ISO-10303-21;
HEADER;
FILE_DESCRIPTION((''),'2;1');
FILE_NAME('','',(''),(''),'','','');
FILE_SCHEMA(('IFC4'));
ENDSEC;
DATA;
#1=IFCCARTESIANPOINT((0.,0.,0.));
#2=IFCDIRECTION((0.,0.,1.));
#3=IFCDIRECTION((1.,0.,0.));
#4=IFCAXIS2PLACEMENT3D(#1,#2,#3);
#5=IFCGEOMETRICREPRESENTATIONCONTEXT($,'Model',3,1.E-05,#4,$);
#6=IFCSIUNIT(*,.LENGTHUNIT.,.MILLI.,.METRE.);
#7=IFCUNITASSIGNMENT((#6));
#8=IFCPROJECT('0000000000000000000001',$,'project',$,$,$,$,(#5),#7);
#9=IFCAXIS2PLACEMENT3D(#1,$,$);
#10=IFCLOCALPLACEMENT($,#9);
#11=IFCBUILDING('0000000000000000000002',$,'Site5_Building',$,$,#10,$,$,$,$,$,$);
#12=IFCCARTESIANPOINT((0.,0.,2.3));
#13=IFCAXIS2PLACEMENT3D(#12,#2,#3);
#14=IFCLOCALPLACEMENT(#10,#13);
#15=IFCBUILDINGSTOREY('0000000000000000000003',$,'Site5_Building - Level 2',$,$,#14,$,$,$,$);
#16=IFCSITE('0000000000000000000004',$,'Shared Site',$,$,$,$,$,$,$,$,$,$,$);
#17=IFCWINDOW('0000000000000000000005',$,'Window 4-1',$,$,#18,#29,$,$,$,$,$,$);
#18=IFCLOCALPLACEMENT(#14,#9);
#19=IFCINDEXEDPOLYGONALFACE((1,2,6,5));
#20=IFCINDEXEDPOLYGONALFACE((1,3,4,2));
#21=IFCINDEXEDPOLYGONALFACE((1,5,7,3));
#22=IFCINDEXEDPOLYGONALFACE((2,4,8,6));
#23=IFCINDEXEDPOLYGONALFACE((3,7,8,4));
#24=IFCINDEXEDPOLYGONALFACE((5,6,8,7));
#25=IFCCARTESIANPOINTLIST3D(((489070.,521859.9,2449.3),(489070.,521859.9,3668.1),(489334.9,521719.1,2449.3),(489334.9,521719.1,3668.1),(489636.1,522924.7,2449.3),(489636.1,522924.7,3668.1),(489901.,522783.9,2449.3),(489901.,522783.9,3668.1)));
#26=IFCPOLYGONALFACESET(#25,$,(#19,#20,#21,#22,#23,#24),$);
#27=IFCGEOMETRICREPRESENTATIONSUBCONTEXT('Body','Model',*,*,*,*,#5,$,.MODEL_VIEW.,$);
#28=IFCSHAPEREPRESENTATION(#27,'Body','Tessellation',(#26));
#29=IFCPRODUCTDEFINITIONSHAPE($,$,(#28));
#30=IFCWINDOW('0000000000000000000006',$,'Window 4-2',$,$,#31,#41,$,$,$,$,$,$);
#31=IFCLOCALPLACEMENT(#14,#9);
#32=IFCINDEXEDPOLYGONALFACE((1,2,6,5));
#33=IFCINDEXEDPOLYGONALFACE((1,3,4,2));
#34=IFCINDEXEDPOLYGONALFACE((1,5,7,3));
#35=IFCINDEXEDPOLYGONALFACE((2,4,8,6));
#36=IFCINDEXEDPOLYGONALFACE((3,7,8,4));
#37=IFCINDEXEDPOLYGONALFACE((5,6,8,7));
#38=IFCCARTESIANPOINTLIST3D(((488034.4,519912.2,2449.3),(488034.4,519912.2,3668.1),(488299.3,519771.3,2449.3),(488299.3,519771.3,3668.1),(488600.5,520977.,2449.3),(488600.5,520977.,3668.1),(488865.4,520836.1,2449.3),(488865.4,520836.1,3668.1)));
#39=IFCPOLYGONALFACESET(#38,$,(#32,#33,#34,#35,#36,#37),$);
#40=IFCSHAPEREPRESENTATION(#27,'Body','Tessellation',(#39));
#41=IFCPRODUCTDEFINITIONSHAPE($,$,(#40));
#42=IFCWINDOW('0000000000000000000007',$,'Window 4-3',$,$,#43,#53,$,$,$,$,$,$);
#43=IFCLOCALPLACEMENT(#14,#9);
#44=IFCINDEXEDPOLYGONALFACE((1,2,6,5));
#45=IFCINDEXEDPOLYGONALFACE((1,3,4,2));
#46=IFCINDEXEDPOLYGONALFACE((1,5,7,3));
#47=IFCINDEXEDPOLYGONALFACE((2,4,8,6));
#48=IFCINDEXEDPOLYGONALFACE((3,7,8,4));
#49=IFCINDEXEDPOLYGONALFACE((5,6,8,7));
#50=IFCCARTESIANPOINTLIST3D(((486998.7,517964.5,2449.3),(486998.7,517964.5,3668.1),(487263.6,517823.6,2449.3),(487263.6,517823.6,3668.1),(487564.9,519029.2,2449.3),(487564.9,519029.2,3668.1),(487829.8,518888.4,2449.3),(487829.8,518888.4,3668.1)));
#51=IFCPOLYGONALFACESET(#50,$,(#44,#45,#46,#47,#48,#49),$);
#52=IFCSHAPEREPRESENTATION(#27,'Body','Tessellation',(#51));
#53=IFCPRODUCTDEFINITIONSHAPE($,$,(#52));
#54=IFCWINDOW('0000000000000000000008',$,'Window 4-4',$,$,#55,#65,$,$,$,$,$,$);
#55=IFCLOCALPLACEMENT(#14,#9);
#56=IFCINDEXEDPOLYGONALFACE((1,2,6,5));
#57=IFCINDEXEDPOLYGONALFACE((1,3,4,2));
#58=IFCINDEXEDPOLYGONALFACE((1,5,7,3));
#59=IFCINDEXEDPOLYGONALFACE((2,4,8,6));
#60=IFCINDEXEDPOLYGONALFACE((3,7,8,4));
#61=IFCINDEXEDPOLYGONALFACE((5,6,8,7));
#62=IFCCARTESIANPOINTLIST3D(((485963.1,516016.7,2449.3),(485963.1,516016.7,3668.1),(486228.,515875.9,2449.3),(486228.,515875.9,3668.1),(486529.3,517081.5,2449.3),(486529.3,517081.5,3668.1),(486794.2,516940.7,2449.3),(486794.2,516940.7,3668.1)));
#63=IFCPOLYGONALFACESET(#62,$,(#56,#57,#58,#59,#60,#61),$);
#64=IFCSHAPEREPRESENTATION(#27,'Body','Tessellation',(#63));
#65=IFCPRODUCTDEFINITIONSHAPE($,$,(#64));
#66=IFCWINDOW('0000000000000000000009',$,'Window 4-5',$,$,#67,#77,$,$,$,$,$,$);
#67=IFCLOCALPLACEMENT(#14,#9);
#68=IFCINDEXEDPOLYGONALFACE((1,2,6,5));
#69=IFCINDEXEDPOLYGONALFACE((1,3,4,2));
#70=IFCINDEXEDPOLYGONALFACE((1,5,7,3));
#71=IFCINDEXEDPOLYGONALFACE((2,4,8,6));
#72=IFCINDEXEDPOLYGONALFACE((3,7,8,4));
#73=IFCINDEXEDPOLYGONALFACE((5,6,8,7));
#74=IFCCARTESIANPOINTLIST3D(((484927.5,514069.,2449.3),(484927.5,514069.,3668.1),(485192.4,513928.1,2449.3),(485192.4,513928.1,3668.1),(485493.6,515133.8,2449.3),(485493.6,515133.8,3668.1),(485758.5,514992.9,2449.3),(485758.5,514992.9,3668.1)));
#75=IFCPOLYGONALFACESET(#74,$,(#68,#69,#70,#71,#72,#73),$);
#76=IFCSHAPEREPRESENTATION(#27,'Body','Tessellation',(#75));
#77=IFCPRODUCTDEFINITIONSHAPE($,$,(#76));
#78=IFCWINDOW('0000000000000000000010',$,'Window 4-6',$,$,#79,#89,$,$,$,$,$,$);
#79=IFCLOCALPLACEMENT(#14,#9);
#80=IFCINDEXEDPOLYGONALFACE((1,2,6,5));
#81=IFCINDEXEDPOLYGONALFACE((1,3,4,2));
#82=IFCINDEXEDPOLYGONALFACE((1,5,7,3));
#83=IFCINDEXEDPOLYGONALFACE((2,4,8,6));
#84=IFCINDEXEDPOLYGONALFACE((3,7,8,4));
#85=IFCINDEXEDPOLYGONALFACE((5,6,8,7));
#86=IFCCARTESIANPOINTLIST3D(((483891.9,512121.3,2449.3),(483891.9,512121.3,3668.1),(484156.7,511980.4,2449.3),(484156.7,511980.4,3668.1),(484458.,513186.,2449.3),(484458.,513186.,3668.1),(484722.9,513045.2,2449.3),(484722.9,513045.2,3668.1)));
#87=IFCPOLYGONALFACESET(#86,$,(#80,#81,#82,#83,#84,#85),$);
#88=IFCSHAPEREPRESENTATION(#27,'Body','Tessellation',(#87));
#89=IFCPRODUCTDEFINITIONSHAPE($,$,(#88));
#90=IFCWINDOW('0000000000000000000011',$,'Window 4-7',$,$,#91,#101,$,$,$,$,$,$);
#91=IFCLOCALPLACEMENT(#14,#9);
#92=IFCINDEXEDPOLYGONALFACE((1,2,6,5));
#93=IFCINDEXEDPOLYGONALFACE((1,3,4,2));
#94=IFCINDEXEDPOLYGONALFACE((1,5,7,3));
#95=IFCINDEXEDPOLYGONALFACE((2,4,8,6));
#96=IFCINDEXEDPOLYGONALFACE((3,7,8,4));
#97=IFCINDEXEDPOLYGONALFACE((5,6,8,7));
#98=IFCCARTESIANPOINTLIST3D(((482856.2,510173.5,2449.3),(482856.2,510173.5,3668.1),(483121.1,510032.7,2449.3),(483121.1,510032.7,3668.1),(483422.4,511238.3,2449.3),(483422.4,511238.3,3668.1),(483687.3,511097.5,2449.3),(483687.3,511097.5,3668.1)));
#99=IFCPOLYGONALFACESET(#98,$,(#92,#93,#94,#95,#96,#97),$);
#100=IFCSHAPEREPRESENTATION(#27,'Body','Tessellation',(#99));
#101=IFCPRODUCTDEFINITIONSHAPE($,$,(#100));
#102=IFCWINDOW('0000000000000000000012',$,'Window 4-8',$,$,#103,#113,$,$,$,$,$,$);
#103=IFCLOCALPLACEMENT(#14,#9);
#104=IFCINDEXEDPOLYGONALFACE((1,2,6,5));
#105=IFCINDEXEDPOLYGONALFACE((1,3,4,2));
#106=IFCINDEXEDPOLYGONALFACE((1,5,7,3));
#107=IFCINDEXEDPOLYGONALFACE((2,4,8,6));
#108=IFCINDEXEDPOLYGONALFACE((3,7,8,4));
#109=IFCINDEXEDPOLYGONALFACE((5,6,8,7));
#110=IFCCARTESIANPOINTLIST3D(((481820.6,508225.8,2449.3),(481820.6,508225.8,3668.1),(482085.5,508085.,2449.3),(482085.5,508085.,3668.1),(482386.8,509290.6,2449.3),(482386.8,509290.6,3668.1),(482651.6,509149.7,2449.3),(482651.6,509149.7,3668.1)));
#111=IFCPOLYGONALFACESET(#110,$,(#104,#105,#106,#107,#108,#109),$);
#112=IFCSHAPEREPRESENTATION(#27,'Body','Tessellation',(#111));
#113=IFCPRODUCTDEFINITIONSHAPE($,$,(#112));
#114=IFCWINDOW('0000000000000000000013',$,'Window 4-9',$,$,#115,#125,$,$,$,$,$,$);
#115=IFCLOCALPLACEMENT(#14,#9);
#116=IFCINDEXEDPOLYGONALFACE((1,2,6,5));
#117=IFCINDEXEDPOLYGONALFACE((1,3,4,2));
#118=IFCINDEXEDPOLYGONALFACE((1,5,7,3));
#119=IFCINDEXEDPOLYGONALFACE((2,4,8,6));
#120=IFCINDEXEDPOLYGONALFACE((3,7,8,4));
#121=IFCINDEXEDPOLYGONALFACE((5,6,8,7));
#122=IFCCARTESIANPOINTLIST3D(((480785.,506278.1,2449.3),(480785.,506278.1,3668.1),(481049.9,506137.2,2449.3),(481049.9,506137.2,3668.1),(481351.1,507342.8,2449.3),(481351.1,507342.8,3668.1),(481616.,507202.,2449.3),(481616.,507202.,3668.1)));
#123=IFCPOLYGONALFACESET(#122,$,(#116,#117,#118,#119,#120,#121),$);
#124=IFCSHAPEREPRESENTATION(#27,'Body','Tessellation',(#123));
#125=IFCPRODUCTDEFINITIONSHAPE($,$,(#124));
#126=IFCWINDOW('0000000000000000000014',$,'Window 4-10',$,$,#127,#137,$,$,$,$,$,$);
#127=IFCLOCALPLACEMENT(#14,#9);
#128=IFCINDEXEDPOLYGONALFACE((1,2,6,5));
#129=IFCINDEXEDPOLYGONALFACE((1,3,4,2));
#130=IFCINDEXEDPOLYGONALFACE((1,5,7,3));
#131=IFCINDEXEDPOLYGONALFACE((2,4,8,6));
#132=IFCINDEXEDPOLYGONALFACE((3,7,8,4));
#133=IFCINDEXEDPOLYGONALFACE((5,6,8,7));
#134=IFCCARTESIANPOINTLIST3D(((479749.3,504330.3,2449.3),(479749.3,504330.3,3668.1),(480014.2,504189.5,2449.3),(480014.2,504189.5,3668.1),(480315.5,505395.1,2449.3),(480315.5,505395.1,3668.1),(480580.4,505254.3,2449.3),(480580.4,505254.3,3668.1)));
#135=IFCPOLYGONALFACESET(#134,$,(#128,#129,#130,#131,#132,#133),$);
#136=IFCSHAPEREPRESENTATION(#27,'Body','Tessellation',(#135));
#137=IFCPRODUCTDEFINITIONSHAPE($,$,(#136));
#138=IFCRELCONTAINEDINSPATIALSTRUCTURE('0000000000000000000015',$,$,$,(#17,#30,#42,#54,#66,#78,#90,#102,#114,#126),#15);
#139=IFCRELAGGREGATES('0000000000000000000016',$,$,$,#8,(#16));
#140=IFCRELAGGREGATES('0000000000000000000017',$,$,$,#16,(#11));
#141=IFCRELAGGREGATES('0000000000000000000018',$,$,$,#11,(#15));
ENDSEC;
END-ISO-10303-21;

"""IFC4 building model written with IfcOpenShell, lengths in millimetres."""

from ifc_helpers import new_model, si_unit, frame, origin, origin_with_axes, place, context, subcontext, project, spatial, indexed_curve, outline, extrude, element, save


model = new_model("IFC4")

# Units and contexts
model_context = context("Model", 3, precision=1e-05, world=origin_with_axes())
body_context = subcontext(model_context, "Body", "Model", "MODEL_VIEW")
ifc_project = project(units=[si_unit("LENGTHUNIT", "METRE", prefix="MILLI")], contexts=[model_context])

# Site, building, storey
site = spatial("IfcSite", under=ifc_project, Name="Shared Site")
building_placement = place(None, origin())
building = spatial("IfcBuilding", under=site, at=building_placement, Name="Site5_Building")
storey_placement = place(building_placement, frame((0.0, 0.0, 2.3), z_axis=(0.0, 0.0, 1.0), x_axis=(1.0, 0.0, 0.0)))
storey = spatial("IfcBuildingStorey", under=building, at=storey_placement, Name="Site5_Building - Level 2")

# Windows
for number, where, z_axis, x_axis, name in (
    (1, (489636.1, 522924.7, 2449.3), (0.0, 0.0, 1.0), (-0.469472, -0.882948, 0.0), "Window 4-1"),
    (2, (488600.5, 520977.0, 2449.3), (0.0, 0.0, 1.0), (-0.469472, -0.882948, 0.0), "Window 4-2"),
    (3, (487564.9, 519029.2, 2449.3), (0.0, 0.0, 1.0), (-0.469472, -0.882948, 0.0), "Window 4-3"),
    (4, (486529.3, 517081.5, 2449.3), (0.0, 0.0, 1.0), (-0.469472, -0.882948, 0.0), "Window 4-4"),
    (5, (485493.6, 515133.8, 2449.3), (0.0, 0.0, 1.0), (-0.469472, -0.882948, 0.0), "Window 4-5"),
    (6, (484458.0, 513186.0, 2449.3), (0.0, 0.0, 1.0), (-0.469472, -0.882948, 0.0), "Window 4-6"),
    (7, (483422.4, 511238.3, 2449.3), (0.0, 0.0, 1.0), (-0.469472, -0.882948, 0.0), "Window 4-7"),
    (8, (482386.8, 509290.6, 2449.3), (0.0, 0.0, 1.0), (-0.469472, -0.882948, 0.0), "Window 4-8"),
    (9, (481351.1, 507342.8, 2449.3), (0.0, 0.0, 1.0), (-0.469472, -0.882948, 0.0), "Window 4-9"),
    (10, (480315.5, 505395.1, 2449.3), (0.0, 0.0, 1.0), (-0.469472, -0.882948, 0.0), "Window 4-10"),
):
    element("IfcWindow", number, at=place(storey_placement, frame(where, z_axis=z_axis, x_axis=x_axis)), inside=storey, Name=name, context=body_context, shape_type="SweptSolid", body=[
        extrude(outline(indexed_curve([(0.0, 0.0), (0.0, 300.0), (1205.9, 300.0), (1205.9, 0.0), (0.0, 0.0)], self_intersect=False)), origin_with_axes(), (0.0, 0.0, 1.0), 1218.8),
    ])

save(model, "model.ifc")
